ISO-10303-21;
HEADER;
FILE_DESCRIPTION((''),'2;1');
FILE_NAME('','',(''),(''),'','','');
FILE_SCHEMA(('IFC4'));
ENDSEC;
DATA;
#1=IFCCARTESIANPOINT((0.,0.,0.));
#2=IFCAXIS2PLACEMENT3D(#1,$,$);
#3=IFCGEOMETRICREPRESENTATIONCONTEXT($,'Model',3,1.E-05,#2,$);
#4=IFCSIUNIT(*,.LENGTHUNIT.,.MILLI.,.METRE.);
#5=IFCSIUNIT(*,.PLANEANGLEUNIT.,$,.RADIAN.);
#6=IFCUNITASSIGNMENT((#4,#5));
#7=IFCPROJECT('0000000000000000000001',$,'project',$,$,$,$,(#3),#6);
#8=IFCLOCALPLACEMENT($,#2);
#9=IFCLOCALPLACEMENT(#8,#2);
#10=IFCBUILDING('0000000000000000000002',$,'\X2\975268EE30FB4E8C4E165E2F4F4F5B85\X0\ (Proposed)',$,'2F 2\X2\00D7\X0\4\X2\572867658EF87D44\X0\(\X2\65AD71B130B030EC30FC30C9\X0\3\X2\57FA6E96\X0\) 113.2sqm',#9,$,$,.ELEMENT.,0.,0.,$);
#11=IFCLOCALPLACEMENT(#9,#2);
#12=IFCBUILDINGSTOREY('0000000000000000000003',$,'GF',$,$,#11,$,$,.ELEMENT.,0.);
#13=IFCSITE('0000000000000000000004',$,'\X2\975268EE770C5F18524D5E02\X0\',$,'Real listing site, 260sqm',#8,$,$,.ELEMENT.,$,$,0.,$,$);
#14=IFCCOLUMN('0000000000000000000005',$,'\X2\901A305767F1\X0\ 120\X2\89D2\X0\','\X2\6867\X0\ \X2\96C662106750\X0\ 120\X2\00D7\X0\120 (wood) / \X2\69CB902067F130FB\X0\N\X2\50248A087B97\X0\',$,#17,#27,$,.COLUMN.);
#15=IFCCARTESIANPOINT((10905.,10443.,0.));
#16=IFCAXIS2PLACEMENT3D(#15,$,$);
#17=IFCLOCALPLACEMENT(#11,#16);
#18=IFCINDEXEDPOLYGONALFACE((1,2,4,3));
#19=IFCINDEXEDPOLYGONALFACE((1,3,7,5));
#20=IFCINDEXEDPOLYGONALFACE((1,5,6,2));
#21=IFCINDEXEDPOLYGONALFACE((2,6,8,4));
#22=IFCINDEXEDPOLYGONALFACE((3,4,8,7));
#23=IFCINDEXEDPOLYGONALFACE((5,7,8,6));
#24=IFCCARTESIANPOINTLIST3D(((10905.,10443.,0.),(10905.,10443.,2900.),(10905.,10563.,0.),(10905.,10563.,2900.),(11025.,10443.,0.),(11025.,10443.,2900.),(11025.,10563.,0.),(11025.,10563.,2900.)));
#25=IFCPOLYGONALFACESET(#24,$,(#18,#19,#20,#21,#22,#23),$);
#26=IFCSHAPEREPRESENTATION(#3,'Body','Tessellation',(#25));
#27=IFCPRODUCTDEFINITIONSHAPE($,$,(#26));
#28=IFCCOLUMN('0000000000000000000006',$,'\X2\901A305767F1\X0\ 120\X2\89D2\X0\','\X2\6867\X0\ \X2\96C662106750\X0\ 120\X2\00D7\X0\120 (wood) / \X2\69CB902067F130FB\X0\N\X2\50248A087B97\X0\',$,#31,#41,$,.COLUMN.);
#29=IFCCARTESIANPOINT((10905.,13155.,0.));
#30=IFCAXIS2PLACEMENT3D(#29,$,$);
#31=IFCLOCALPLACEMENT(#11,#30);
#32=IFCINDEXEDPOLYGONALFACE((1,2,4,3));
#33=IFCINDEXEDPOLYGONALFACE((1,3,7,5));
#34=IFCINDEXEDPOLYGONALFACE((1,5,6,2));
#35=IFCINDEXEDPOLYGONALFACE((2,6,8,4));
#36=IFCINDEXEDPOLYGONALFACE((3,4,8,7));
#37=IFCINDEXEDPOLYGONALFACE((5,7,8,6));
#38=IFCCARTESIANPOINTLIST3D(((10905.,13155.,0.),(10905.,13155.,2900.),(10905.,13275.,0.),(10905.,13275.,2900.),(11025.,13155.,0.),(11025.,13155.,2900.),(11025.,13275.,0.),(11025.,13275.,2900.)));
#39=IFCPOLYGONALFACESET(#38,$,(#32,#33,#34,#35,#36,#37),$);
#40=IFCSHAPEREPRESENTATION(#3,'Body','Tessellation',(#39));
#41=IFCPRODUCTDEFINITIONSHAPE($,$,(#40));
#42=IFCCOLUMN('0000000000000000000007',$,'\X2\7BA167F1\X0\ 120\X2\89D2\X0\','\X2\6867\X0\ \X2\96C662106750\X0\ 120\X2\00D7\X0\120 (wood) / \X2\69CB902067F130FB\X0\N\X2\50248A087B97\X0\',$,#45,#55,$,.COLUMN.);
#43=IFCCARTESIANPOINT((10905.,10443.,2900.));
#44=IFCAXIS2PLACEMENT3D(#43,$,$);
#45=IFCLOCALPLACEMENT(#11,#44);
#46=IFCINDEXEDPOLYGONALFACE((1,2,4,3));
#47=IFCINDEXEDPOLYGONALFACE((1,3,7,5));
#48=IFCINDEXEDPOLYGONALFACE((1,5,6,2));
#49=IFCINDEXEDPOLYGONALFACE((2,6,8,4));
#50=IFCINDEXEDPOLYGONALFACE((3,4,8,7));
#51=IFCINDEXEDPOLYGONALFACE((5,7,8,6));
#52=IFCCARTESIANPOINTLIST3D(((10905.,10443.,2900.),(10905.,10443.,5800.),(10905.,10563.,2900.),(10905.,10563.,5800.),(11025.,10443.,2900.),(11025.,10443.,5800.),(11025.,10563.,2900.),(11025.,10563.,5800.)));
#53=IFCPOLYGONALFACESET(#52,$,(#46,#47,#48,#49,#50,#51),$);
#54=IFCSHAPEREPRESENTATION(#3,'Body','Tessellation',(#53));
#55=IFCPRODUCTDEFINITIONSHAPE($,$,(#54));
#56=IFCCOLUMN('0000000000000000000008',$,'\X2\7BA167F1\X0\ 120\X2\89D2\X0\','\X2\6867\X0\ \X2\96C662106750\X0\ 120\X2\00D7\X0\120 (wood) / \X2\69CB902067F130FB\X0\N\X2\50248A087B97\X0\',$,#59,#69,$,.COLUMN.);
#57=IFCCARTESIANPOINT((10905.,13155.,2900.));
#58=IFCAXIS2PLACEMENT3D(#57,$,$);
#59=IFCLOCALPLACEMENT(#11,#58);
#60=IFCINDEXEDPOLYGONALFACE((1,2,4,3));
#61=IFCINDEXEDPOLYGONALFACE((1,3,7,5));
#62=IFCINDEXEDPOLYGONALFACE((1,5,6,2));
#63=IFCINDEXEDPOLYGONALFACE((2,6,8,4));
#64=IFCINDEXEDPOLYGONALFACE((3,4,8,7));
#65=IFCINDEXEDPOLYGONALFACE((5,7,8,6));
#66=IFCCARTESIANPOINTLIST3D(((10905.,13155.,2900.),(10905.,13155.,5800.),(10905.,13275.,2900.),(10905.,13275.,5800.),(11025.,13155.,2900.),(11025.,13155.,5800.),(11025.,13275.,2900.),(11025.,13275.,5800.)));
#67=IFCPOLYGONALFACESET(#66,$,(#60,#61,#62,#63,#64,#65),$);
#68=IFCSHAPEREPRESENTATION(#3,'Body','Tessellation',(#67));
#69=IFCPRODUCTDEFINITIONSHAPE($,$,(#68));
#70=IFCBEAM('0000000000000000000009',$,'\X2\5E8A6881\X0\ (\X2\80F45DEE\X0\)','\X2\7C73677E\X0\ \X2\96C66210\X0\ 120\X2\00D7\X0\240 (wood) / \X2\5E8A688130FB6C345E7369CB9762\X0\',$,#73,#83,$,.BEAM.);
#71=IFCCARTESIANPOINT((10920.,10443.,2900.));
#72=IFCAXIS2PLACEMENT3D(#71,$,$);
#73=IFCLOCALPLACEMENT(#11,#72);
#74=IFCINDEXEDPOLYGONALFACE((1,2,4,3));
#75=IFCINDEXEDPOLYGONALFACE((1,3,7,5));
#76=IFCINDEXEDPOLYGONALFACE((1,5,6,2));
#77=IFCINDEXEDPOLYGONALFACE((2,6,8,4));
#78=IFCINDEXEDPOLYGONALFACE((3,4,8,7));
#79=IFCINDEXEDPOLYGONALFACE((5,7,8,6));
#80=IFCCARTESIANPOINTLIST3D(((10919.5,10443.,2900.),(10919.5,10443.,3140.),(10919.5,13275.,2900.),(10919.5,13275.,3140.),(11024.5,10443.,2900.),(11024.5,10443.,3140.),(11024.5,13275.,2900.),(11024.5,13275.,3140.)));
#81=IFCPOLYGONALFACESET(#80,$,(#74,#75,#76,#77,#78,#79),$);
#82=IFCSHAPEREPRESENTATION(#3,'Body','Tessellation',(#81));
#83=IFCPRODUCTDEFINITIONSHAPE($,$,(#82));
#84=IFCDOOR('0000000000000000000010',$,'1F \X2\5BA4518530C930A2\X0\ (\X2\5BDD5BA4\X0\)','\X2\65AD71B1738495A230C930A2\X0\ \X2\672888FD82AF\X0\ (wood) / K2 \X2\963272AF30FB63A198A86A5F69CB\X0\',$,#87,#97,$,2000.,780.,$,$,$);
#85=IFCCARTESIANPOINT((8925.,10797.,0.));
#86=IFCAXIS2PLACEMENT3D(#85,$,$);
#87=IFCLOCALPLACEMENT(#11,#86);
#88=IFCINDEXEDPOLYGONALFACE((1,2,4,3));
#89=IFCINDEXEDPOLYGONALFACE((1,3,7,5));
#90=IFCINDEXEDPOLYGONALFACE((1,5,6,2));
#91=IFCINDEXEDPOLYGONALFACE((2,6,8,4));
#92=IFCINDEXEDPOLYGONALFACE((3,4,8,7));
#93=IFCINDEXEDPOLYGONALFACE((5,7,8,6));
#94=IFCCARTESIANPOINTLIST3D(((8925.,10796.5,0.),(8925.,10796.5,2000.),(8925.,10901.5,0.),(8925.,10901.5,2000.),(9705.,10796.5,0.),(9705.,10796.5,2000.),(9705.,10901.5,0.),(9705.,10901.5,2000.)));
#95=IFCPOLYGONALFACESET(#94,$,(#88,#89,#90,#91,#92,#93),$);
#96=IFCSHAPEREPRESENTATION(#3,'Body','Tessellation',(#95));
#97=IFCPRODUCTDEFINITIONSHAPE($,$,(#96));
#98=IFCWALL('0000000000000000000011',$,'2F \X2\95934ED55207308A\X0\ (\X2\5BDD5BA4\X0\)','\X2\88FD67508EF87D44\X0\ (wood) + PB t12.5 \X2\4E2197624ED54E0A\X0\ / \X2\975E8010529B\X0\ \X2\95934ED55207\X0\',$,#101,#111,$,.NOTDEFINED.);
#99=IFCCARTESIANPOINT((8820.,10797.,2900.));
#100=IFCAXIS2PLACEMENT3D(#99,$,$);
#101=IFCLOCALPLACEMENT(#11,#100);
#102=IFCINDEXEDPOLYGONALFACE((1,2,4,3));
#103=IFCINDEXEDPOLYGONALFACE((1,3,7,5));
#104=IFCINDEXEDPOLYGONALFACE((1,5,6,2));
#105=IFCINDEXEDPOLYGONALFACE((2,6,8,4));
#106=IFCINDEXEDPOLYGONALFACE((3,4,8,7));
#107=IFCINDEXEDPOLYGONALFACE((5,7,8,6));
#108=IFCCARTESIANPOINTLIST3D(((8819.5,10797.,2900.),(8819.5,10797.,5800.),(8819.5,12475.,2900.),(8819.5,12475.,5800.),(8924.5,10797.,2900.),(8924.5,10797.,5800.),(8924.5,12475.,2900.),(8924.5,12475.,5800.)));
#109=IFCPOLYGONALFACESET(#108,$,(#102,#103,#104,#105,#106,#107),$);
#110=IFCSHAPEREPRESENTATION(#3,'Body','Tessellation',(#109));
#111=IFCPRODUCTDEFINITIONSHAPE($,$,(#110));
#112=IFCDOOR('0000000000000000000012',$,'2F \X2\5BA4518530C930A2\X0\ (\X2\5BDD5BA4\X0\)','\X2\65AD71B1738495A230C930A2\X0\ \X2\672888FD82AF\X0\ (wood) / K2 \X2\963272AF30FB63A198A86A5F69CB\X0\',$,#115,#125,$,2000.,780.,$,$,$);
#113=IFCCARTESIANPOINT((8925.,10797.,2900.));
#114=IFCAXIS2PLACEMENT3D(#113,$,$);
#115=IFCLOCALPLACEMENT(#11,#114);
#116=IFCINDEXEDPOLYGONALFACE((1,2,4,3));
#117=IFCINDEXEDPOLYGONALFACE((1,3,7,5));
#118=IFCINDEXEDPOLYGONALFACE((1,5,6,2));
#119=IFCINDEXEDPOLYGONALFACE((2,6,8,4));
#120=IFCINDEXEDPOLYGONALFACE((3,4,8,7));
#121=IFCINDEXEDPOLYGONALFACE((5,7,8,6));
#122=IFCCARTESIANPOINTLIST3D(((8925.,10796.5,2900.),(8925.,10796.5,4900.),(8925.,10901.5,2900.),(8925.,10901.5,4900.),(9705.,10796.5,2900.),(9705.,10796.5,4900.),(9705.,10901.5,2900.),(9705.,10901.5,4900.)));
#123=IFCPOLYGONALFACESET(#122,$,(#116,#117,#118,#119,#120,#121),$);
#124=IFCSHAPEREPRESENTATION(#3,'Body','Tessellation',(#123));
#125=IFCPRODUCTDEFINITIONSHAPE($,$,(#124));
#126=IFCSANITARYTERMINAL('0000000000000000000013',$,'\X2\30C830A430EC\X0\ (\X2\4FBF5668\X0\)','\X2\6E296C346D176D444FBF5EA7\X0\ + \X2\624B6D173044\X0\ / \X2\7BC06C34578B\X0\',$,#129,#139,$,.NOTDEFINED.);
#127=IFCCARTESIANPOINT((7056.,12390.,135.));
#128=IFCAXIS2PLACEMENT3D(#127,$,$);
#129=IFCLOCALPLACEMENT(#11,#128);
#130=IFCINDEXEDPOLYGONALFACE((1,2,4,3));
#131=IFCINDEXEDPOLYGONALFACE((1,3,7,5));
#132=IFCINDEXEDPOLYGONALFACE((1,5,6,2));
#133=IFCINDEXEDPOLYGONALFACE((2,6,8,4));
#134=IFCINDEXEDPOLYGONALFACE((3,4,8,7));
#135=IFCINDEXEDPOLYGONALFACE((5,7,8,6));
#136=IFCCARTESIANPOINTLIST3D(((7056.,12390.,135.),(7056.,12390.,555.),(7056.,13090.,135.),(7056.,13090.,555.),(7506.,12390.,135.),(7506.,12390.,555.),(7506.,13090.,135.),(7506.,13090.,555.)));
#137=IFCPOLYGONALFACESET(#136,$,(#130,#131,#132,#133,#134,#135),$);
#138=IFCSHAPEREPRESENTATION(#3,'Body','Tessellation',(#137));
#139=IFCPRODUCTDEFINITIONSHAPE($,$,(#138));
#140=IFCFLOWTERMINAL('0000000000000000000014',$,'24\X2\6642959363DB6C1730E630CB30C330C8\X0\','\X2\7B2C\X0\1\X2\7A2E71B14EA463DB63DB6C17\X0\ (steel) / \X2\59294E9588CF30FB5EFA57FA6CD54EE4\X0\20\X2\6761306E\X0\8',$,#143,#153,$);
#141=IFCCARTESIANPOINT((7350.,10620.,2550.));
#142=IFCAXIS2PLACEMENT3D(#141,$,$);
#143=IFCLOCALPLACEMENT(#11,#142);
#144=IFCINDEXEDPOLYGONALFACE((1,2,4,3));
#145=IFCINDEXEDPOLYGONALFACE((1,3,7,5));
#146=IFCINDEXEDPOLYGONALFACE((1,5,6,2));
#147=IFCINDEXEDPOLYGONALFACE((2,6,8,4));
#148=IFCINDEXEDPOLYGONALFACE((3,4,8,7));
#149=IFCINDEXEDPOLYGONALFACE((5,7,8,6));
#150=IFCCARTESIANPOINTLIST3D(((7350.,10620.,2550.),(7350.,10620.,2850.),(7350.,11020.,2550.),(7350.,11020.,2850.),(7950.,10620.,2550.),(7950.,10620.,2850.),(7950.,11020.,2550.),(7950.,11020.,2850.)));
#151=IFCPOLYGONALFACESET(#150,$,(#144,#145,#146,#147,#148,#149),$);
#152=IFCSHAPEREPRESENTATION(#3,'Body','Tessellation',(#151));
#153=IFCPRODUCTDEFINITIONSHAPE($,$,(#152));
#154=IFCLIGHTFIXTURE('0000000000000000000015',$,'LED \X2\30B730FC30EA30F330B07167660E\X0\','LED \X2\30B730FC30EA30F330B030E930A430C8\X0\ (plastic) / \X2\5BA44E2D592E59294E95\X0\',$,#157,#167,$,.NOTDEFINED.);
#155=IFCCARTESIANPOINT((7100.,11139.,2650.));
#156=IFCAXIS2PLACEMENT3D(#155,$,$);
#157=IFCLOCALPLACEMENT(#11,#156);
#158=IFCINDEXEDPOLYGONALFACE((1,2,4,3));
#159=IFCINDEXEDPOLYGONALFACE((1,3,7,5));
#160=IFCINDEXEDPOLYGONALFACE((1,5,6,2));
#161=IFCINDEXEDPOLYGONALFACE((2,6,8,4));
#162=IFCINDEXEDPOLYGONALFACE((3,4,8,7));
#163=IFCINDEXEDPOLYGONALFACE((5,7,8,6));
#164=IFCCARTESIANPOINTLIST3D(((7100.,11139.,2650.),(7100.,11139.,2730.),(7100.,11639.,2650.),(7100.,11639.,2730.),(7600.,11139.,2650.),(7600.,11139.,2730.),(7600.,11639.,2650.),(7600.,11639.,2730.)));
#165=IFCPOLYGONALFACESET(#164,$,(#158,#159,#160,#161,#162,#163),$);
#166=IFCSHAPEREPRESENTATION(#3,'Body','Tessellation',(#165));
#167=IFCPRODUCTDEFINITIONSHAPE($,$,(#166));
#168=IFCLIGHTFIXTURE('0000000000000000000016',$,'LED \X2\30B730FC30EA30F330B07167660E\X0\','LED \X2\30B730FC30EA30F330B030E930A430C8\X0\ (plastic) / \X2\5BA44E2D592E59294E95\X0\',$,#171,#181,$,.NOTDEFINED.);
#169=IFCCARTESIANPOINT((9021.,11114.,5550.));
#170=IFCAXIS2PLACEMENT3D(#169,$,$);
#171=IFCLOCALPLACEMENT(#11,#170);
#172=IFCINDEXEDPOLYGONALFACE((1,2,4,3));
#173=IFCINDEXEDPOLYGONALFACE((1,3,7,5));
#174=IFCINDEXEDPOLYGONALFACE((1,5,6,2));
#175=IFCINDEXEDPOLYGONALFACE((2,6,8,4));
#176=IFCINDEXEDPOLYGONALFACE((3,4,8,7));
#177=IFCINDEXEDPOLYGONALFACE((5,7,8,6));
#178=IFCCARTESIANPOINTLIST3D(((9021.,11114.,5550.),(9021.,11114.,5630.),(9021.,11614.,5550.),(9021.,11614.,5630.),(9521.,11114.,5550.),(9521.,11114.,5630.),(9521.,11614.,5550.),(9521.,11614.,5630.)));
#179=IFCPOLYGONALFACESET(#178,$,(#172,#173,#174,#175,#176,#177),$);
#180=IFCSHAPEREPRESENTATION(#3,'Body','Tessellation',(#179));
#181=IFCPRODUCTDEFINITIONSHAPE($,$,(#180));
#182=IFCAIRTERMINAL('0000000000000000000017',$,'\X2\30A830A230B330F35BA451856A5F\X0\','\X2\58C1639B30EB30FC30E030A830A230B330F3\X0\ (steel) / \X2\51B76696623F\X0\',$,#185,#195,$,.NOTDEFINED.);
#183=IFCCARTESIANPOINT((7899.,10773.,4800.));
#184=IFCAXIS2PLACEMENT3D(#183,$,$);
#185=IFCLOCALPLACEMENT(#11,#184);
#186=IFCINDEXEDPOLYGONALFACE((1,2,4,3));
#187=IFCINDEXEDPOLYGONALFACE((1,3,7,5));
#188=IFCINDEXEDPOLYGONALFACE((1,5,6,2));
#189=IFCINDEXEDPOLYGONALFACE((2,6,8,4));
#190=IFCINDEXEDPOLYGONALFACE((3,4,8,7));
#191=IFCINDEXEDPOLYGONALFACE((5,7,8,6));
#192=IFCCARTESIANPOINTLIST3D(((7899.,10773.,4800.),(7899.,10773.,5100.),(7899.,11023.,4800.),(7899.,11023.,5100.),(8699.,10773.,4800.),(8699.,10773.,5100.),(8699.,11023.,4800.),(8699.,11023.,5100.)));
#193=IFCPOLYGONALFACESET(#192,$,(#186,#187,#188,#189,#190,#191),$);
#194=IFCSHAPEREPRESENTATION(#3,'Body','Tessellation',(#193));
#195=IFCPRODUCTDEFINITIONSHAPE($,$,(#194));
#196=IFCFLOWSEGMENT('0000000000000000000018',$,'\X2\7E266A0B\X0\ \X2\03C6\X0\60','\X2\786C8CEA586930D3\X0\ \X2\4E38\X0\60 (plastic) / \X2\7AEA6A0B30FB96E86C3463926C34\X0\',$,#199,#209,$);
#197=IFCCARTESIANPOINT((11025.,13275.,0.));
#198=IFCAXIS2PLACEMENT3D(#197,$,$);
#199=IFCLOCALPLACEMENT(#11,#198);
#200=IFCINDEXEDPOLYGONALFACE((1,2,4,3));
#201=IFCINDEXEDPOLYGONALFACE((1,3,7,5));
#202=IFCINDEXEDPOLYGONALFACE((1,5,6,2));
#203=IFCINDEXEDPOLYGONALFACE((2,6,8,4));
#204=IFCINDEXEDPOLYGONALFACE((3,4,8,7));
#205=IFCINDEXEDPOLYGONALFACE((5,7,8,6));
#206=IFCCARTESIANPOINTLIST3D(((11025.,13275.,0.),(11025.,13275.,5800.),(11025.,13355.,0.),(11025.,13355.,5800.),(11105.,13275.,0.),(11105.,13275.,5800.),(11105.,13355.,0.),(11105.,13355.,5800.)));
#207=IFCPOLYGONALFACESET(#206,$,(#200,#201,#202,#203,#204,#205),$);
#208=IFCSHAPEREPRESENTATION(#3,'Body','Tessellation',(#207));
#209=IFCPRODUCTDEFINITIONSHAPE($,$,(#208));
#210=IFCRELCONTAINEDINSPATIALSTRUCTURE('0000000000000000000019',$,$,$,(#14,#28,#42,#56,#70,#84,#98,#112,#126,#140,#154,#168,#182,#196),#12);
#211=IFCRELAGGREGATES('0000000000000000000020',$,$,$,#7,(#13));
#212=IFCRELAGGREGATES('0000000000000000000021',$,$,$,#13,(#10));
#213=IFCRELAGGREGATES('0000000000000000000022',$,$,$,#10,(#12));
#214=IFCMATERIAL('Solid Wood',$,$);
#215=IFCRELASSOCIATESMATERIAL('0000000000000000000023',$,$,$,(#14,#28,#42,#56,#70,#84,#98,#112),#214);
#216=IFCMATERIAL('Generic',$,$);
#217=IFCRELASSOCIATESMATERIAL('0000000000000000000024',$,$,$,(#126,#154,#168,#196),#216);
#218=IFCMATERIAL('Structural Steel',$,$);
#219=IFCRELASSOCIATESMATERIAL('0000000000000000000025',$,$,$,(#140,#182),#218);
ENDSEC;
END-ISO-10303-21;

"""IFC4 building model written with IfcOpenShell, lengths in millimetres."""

from ifc_helpers import new_model, si_unit, frame, frame_2d, origin, place, context, project, spatial, rectangle, extrude, material, element, save


model = new_model("IFC4")

# Units and contexts
model_context = context("Model", 3, precision=1e-05, world=origin())
ifc_project = project(units=[si_unit("LENGTHUNIT", "METRE", prefix="MILLI"), si_unit("PLANEANGLEUNIT", "RADIAN")], contexts=[model_context])

# Site, building, storey
site_placement = place(None, origin())
site = spatial("IfcSite", under=ifc_project, at=site_placement, Name="青森県弘前市", ObjectType="Real listing site, 260sqm", CompositionType="ELEMENT", RefElevation=0.0)
building_placement = place(site_placement, origin())
building = spatial("IfcBuilding", under=site, at=building_placement, Name="青森・二世帯住宅 (Proposed)", ObjectType="2F 2×4在来軸組(断熱グレード3基準) 113.2sqm", CompositionType="ELEMENT", ElevationOfRefHeight=0.0, ElevationOfTerrain=0.0)
storey_placement = place(building_placement, origin())
storey = spatial("IfcBuildingStorey", under=building, at=storey_placement, Name="GF", CompositionType="ELEMENT", Elevation=0.0)

# Columns
ifc_material_1 = material(Name="Solid Wood")
column_1_placement = place(storey_placement, frame((10905.0, 10443.0, 0.0)))
element("IfcColumn", 1, at=column_1_placement, inside=storey, material=ifc_material_1, Name="通し柱 120角", Description="桧 集成材 120×120 (wood) / 構造柱・N値計算", PredefinedType="COLUMN", context=model_context, shape_type="SweptSolid", body=[
    extrude(rectangle(XDim=120.0, YDim=120.0, at=frame_2d((60.0, 60.0))), frame((10905.0, 10443.0, 0.0)), (0.0, 0.0, 1.0), 2900.0),
])
column_2_placement = place(storey_placement, frame((10905.0, 13155.0, 0.0)))
element("IfcColumn", 2, at=column_2_placement, inside=storey, material=ifc_material_1, Name="通し柱 120角", Description="桧 集成材 120×120 (wood) / 構造柱・N値計算", PredefinedType="COLUMN", context=model_context, shape_type="SweptSolid", body=[
    extrude(rectangle(XDim=120.0, YDim=120.0, at=frame_2d((60.0, 60.0))), frame((10905.0, 13155.0, 0.0)), (0.0, 0.0, 1.0), 2900.0),
])
column_3_placement = place(storey_placement, frame((10905.0, 10443.0, 2900.0)))
element("IfcColumn", 3, at=column_3_placement, inside=storey, material=ifc_material_1, Name="管柱 120角", Description="桧 集成材 120×120 (wood) / 構造柱・N値計算", PredefinedType="COLUMN", context=model_context, shape_type="SweptSolid", body=[
    extrude(rectangle(XDim=120.0, YDim=120.0, at=frame_2d((60.0, 60.0))), frame((10905.0, 10443.0, 2900.0)), (0.0, 0.0, 1.0), 2900.0),
])
column_4_placement = place(storey_placement, frame((10905.0, 13155.0, 2900.0)))
element("IfcColumn", 4, at=column_4_placement, inside=storey, material=ifc_material_1, Name="管柱 120角", Description="桧 集成材 120×120 (wood) / 構造柱・N値計算", PredefinedType="COLUMN", context=model_context, shape_type="SweptSolid", body=[
    extrude(rectangle(XDim=120.0, YDim=120.0, at=frame_2d((60.0, 60.0))), frame((10905.0, 13155.0, 2900.0)), (0.0, 0.0, 1.0), 2900.0),
])

# Beam
beam_1_placement = place(storey_placement, frame((10920.0, 10443.0, 2900.0)))
element("IfcBeam", 5, at=beam_1_placement, inside=storey, material=ifc_material_1, Name="床梁 (胴差)", Description="米松 集成 120×240 (wood) / 床梁・水平構面", PredefinedType="BEAM", context=model_context, shape_type="SweptSolid", body=[
    extrude(rectangle(XDim=105.0, YDim=2832.0, at=frame_2d((52.0, 1416.0))), frame((10920.0, 10443.0, 2900.0)), (0.0, 0.0, 1.0), 240.0),
])

# Door
door_1_placement = place(storey_placement, frame((8925.0, 10797.0, 0.0)))
element("IfcDoor", 6, at=door_1_placement, inside=storey, material=ifc_material_1, Name="1F 室内ドア (寝室)", Description="断熱玄関ドア 木製芯 (wood) / K2 防犯・採風機構", OverallHeight=2000.0, OverallWidth=780.0, context=model_context, shape_type="SweptSolid", body=[
    extrude(rectangle(XDim=780.0, YDim=105.0, at=frame_2d((390.0, 52.0))), frame((8925.0, 10797.0, 0.0)), (0.0, 0.0, 1.0), 2000.0),
])

# Wall
wall_1_placement = place(storey_placement, frame((8820.0, 10797.0, 2900.0)))
element("IfcWall", 7, at=wall_1_placement, inside=storey, material=ifc_material_1, Name="2F 間仕切り (寝室)", Description="製材軸組 (wood) + PB t12.5 両面仕上 / 非耐力 間仕切", PredefinedType="NOTDEFINED", context=model_context, shape_type="SweptSolid", body=[
    extrude(rectangle(XDim=105.0, YDim=1678.0, at=frame_2d((52.0, 839.0))), frame((8820.0, 10797.0, 2900.0)), (0.0, 0.0, 1.0), 2900.0),
])

# Door
door_2_placement = place(storey_placement, frame((8925.0, 10797.0, 2900.0)))
element("IfcDoor", 8, at=door_2_placement, inside=storey, material=ifc_material_1, Name="2F 室内ドア (寝室)", Description="断熱玄関ドア 木製芯 (wood) / K2 防犯・採風機構", OverallHeight=2000.0, OverallWidth=780.0, context=model_context, shape_type="SweptSolid", body=[
    extrude(rectangle(XDim=780.0, YDim=105.0, at=frame_2d((390.0, 52.0))), frame((8925.0, 10797.0, 2900.0)), (0.0, 0.0, 1.0), 2000.0),
])

# Sanitary terminal
ifc_material_2 = material(Name="Generic")
sanitary_terminal_placement = place(storey_placement, frame((7056.0, 12390.0, 135.0)))
element("IfcSanitaryTerminal", 9, at=sanitary_terminal_placement, inside=storey, material=ifc_material_2, Name="トイレ (便器)", Description="温水洗浄便座 + 手洗い / 節水型", PredefinedType="NOTDEFINED", context=model_context, shape_type="SweptSolid", body=[
    extrude(rectangle(XDim=450.0, YDim=700.0, at=frame_2d((225.0, 350.0))), frame((7056.0, 12390.0, 135.0)), (0.0, 0.0, 1.0), 420.0),
])

# Flow terminal
ifc_material_3 = material(Name="Structural Steel")
flow_terminal_placement = place(storey_placement, frame((7350.0, 10620.0, 2550.0)))
element("IfcFlowTerminal", 10, at=flow_terminal_placement, inside=storey, material=ifc_material_3, Name="24時間換気ユニット", Description="第1種熱交換換気 (steel) / 天井裏・建基法令20条の8", context=model_context, shape_type="SweptSolid", body=[
    extrude(rectangle(XDim=600.0, YDim=400.0, at=frame_2d((300.0, 200.0))), frame((7350.0, 10620.0, 2550.0)), (0.0, 0.0, 1.0), 300.0),
])

# Light fixtures
light_fixture_1_placement = place(storey_placement, frame((7100.0, 11139.0, 2650.0)))
element("IfcLightFixture", 11, at=light_fixture_1_placement, inside=storey, material=ifc_material_2, Name="LED シーリング照明", Description="LED シーリングライト (plastic) / 室中央天井", PredefinedType="NOTDEFINED", context=model_context, shape_type="SweptSolid", body=[
    extrude(rectangle(XDim=500.0, YDim=500.0, at=frame_2d((250.0, 250.0))), frame((7100.0, 11139.0, 2650.0)), (0.0, 0.0, 1.0), 80.0),
])
light_fixture_2_placement = place(storey_placement, frame((9021.0, 11114.0, 5550.0)))
element("IfcLightFixture", 12, at=light_fixture_2_placement, inside=storey, material=ifc_material_2, Name="LED シーリング照明", Description="LED シーリングライト (plastic) / 室中央天井", PredefinedType="NOTDEFINED", context=model_context, shape_type="SweptSolid", body=[
    extrude(rectangle(XDim=500.0, YDim=500.0, at=frame_2d((250.0, 250.0))), frame((9021.0, 11114.0, 5550.0)), (0.0, 0.0, 1.0), 80.0),
])

# Air terminal
air_terminal_placement = place(storey_placement, frame((7899.0, 10773.0, 4800.0)))
element("IfcAirTerminal", 13, at=air_terminal_placement, inside=storey, material=ifc_material_3, Name="エアコン室内機", Description="壁掛ルームエアコン (steel) / 冷暖房", PredefinedType="NOTDEFINED", context=model_context, shape_type="SweptSolid", body=[
    extrude(rectangle(XDim=800.0, YDim=250.0, at=frame_2d((400.0, 125.0))), frame((7899.0, 10773.0, 4800.0)), (0.0, 0.0, 1.0), 300.0),
])

# Flow segment
flow_segment_placement = place(storey_placement, frame((11025.0, 13275.0, 0.0)))
element("IfcFlowSegment", 14, at=flow_segment_placement, inside=storey, material=ifc_material_2, Name="縦樋 φ60", Description="硬質塩ビ 丸60 (plastic) / 竪樋・雨水排水", context=model_context, shape_type="SweptSolid", body=[
    extrude(rectangle(XDim=80.0, YDim=80.0, at=frame_2d((40.0, 40.0))), frame((11025.0, 13275.0, 0.0)), (0.0, 0.0, 1.0), 5800.0),
])

save(model, "model.ifc")
